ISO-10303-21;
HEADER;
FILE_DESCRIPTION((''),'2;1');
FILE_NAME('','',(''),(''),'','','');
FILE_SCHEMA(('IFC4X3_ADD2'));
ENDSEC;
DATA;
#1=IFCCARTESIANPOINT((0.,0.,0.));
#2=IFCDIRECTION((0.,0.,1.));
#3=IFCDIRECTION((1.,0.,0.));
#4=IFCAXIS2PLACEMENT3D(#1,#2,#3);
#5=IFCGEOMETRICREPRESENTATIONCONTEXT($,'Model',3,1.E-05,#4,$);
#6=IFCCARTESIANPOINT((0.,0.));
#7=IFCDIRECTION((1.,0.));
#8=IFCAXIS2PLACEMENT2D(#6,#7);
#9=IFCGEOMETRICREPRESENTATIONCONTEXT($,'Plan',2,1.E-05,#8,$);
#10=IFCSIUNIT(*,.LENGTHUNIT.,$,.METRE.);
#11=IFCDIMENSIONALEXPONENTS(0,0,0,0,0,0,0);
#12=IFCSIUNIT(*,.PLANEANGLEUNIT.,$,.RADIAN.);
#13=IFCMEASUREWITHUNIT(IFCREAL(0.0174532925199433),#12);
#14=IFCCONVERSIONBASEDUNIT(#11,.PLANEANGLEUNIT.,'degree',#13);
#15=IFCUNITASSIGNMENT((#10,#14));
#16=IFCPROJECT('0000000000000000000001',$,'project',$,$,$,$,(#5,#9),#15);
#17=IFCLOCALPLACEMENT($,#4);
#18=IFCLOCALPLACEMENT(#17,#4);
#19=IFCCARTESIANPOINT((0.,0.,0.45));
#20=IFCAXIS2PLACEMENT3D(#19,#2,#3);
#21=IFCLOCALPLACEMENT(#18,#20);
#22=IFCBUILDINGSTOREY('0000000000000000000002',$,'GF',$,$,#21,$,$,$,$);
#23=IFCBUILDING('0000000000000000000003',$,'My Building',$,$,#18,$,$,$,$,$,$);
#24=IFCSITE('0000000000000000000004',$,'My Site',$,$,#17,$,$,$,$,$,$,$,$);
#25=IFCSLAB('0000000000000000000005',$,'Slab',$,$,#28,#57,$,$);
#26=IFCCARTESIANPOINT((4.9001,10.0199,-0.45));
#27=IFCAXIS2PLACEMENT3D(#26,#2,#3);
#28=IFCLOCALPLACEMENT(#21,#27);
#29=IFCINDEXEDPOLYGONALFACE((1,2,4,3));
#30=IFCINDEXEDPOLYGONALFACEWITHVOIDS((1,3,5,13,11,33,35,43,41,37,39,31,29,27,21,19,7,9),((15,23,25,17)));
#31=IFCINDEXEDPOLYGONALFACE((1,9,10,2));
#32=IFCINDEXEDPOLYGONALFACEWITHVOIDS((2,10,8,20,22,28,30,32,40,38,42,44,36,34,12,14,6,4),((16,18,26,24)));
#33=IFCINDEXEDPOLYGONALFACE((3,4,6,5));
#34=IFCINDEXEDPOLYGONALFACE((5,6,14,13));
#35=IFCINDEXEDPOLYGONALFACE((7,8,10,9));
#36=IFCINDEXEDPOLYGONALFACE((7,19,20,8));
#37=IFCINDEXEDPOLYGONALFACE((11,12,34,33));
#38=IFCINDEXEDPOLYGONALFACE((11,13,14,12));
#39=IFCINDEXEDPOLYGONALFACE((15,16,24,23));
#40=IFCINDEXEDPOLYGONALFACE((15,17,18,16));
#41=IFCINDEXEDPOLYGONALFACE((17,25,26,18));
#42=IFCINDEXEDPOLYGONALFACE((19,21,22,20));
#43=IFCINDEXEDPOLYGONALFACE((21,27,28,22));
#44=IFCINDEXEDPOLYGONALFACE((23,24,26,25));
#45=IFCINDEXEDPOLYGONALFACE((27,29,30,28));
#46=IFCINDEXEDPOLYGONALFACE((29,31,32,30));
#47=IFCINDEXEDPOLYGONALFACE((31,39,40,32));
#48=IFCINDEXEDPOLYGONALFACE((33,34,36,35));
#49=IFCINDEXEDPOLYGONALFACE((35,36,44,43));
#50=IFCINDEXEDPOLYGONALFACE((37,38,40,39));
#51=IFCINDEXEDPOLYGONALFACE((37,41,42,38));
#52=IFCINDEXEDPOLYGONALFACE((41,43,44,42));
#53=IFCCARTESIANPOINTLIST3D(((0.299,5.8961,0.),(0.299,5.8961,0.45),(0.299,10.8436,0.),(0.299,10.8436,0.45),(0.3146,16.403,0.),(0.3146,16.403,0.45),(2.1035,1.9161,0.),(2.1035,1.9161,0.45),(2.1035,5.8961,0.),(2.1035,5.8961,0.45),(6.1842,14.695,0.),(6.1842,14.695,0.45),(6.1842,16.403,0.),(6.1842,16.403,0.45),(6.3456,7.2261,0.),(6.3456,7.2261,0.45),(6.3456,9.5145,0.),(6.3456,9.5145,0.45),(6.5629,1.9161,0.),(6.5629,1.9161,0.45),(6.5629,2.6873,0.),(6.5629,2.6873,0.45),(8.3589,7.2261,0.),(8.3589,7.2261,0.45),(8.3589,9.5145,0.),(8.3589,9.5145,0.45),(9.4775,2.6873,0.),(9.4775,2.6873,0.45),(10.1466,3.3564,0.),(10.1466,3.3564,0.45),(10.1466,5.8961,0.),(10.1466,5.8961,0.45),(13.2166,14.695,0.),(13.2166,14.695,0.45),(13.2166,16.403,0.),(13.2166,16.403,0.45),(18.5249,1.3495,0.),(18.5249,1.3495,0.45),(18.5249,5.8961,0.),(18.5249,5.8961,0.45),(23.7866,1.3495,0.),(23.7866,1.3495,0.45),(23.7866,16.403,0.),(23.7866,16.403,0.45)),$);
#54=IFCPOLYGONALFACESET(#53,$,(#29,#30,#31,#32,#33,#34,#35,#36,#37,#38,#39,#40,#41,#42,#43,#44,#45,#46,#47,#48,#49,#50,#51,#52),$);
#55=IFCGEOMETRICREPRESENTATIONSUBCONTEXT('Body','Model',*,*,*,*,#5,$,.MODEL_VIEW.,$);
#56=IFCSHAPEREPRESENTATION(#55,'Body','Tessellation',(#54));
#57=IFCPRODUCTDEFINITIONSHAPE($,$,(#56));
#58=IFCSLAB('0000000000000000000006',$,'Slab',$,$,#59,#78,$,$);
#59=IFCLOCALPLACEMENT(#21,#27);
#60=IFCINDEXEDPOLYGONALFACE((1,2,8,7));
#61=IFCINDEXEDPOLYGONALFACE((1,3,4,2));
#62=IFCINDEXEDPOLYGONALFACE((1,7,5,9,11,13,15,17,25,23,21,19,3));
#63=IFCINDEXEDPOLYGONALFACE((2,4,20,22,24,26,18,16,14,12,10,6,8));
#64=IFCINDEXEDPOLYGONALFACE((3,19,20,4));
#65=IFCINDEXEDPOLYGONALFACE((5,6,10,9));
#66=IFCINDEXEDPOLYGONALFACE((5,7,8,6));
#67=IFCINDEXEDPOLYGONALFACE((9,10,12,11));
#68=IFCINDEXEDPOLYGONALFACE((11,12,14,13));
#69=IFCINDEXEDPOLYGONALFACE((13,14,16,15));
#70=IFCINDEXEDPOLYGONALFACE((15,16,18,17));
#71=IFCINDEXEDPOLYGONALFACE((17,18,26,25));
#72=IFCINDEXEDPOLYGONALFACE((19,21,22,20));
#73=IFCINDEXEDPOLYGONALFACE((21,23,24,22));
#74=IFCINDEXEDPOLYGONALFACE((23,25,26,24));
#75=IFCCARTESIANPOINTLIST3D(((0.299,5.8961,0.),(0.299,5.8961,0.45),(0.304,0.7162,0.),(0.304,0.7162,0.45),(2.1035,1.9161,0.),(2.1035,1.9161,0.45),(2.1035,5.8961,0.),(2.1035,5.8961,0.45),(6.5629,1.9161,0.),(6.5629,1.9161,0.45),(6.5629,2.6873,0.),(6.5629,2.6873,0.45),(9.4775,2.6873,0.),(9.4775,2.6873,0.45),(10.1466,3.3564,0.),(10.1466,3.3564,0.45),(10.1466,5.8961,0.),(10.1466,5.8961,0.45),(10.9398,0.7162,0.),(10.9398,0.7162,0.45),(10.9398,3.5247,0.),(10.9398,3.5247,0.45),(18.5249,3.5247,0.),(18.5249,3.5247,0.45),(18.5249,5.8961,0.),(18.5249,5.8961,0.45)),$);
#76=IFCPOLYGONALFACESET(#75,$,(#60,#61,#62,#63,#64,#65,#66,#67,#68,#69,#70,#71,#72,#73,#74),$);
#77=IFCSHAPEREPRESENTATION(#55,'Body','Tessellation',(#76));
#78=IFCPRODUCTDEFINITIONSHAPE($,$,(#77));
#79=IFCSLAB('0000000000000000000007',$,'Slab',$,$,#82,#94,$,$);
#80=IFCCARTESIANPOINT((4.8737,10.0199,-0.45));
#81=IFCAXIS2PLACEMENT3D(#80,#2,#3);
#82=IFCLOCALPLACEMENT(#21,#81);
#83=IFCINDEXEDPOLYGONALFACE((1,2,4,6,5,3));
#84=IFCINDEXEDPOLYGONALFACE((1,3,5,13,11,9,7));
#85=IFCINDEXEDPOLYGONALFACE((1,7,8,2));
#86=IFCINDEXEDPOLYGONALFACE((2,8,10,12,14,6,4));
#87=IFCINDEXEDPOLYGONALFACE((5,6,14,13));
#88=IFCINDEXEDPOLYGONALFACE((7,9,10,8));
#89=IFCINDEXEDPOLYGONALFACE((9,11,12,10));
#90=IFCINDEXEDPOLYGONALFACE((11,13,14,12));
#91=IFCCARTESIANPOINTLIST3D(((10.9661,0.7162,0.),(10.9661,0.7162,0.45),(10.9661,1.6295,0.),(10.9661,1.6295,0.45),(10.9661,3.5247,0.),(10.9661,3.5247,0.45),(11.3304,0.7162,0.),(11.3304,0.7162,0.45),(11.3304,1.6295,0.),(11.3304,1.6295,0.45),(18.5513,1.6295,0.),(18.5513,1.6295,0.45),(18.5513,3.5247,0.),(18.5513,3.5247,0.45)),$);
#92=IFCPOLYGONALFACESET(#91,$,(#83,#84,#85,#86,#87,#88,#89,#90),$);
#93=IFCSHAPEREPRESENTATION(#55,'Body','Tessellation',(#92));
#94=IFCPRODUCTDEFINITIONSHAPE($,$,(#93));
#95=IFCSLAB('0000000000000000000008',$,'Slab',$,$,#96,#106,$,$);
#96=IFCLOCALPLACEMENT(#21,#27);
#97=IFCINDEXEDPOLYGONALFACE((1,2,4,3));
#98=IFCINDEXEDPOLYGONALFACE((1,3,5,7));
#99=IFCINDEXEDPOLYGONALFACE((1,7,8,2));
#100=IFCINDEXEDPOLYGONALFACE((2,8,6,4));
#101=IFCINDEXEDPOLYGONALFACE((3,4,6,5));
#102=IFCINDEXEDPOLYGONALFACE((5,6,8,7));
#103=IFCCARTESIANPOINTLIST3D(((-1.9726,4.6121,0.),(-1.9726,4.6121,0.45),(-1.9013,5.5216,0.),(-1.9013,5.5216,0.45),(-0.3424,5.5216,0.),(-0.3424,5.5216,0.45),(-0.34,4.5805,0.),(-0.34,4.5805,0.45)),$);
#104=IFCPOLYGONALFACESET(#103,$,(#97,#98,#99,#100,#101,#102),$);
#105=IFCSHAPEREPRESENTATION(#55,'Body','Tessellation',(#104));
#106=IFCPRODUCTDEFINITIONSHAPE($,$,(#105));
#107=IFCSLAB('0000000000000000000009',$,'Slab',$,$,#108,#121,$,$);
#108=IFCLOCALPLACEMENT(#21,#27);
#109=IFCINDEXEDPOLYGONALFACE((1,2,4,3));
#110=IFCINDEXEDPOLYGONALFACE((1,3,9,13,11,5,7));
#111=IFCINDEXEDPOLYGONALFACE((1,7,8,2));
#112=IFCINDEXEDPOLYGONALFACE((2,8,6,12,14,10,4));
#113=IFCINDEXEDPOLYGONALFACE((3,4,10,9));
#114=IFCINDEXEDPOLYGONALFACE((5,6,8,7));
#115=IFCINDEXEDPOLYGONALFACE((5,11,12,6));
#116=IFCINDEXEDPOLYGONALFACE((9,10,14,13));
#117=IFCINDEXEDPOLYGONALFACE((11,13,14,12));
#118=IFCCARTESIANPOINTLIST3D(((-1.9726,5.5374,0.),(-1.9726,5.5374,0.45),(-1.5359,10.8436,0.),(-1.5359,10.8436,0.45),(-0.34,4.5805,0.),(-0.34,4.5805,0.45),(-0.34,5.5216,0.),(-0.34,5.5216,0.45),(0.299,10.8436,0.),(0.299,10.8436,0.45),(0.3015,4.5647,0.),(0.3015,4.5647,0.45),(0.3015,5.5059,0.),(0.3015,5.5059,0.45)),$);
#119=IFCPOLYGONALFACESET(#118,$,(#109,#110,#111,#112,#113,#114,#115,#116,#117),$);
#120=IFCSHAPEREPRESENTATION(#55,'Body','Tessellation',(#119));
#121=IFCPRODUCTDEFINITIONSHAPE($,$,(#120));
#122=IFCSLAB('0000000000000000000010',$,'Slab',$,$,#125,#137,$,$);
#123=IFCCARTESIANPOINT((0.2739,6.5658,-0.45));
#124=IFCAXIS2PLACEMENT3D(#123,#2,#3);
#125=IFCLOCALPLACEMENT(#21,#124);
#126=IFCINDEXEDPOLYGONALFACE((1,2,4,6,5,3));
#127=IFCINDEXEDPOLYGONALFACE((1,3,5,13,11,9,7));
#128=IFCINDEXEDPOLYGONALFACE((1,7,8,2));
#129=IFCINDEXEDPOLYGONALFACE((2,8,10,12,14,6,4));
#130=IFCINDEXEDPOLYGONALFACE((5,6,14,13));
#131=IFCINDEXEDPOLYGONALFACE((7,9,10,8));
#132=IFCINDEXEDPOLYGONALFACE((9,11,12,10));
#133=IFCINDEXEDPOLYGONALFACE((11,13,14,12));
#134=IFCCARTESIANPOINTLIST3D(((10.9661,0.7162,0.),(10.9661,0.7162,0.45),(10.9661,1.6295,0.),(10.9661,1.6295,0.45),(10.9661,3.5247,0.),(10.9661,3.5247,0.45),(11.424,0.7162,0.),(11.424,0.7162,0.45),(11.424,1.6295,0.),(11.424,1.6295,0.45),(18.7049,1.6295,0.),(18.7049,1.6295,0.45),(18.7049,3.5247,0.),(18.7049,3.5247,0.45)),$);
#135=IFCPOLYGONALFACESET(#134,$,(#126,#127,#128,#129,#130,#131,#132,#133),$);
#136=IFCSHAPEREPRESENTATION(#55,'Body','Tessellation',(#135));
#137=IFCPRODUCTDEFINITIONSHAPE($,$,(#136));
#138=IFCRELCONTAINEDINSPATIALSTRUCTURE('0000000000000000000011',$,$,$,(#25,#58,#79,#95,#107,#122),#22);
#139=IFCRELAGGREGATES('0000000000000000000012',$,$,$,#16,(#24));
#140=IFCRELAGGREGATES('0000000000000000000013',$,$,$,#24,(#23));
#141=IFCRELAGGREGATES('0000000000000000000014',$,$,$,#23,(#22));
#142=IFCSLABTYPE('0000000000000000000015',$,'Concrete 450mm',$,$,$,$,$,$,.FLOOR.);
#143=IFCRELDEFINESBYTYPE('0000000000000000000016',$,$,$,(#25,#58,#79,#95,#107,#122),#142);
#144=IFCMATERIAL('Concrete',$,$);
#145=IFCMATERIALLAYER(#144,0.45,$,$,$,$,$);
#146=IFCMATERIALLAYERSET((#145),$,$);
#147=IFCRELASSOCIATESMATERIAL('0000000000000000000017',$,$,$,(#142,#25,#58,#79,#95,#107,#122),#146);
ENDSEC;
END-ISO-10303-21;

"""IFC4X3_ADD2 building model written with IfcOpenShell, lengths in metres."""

from ifc_helpers import new_model, entity, si_unit, converted_unit, frame, origin_with_axes, origin_2d_with_axis, place, context, subcontext, project, spatial, line, indexed_curve, outline, extrude, material, layer, layer_set, layer_usage, type_object, element, save


model = new_model("IFC4X3_ADD2")

# Units and contexts
model_context = context("Model", 3, precision=1e-05, world=origin_with_axes())
plan_context = context("Plan", 2, precision=1e-05, world=origin_2d_with_axis())
body_context_1 = subcontext(model_context, "Body", "Model", "MODEL_VIEW")
ifc_project = project(units=[si_unit("LENGTHUNIT", "METRE"), converted_unit("PLANEANGLEUNIT", "degree", entity("IfcReal", 0.0174532925199433), si_unit("PLANEANGLEUNIT", "RADIAN"), dimensions=[0, 0, 0, 0, 0, 0, 0])], contexts=[model_context, plan_context])

# Site, building, storey
site_placement = place(None, origin_with_axes())
site = spatial("IfcSite", under=ifc_project, at=site_placement, Name="My Site")
building_placement = place(site_placement, origin_with_axes())
building = spatial("IfcBuilding", under=site, at=building_placement, Name="My Building")
storey_placement = place(building_placement, frame((0.0, 0.0, 0.45), z_axis=(0.0, 0.0, 1.0), x_axis=(1.0, 0.0, 0.0)))
storey = spatial("IfcBuildingStorey", under=building, at=storey_placement, Name="GF")

# Slabs
ifc_material_1 = material(Name="Concrete")
ifc_layer_1 = layer(ifc_material_1, 0.45)
ifc_layer_set_1 = layer_set([ifc_layer_1])
ifc_layer_usage_1 = layer_usage(ifc_layer_set_1, "AXIS3", "POSITIVE", 0.0)
slab_type = type_object("IfcSlabType", Name="Concrete 450mm", PredefinedType="FLOOR", material=ifc_layer_set_1)
slab_1_placement = place(storey_placement, frame((4.9001, 10.0199, -0.45), z_axis=(0.0, 0.0, 1.0), x_axis=(1.0, 0.0, 0.0)))
element("IfcSlab", 1, at=slab_1_placement, inside=storey, type_object=slab_type, material=ifc_layer_usage_1, Name="Slab", context=body_context_1, shape_type="SolidModel", body=[
    extrude(outline(indexed_curve([(6.5629, 1.9161), (6.5629, 2.6873), (9.4775, 2.6873), (10.1466, 3.3564), (10.1466, 5.8961), (18.5249, 5.8961), (18.5249, 1.3495), (23.7866, 1.3495), (23.7866, 16.403), (13.2166, 16.403), (13.2166, 14.695), (6.1842, 14.695), (6.1842, 16.403), (0.3146, 16.403), (0.299, 10.8436), (0.299, 5.8961), (2.1035, 5.8961), (2.1035, 1.9161), (6.5629, 1.9161)]), holes=[indexed_curve([(6.3456, 9.5145), (8.3589, 9.5145), (8.3589, 7.2261), (6.3456, 7.2261), (6.3456, 9.5145)])]), None, (0.0, 0.0, 1.0), 0.45),
])
ifc_layer_usage_2 = layer_usage(ifc_layer_set_1, "AXIS3", "POSITIVE", 0.0)
slab_2_placement = place(storey_placement, frame((4.9001, 10.0199, -0.45), z_axis=(0.0, 0.0, 1.0), x_axis=(1.0, 0.0, 0.0)))
element("IfcSlab", 2, at=slab_2_placement, inside=storey, type_object=slab_type, material=ifc_layer_usage_2, Name="Slab", context=body_context_1, shape_type="SweptSolid", body=[
    extrude(outline(indexed_curve([(18.5249, 5.8961), (10.1466, 5.8961), (10.1466, 3.3564), (9.4775, 2.6873), (6.5629, 2.6873), (6.5629, 1.9161), (2.1035, 1.9161), (2.1035, 5.8961), (0.299, 5.8961), (0.304, 0.7162), (10.9398, 0.7162), (10.9398, 3.5247), (18.5249, 3.5247)], segments=[line(10, 9), line(9, 8), line(8, 7), line(7, 6), line(6, 5), line(5, 4), line(4, 3), line(3, 2), line(2, 1), line(1, 13), line(13, 12), line(12, 11), line(11, 10)], self_intersect=False)), None, (0.0, 0.0, 1.0), 0.45),
])
ifc_layer_usage_3 = layer_usage(ifc_layer_set_1, "AXIS3", "POSITIVE", 0.0)
slab_3_placement = place(storey_placement, frame((4.8737, 10.0199, -0.45), z_axis=(0.0, 0.0, 1.0), x_axis=(1.0, 0.0, 0.0)))
element("IfcSlab", 3, at=slab_3_placement, inside=storey, type_object=slab_type, material=ifc_layer_usage_3, Name="Slab", context=body_context_1, shape_type="SolidModel", body=[
    extrude(outline(indexed_curve([(10.9661, 1.6295), (10.9661, 3.5247), (18.5513, 3.5247), (18.5513, 1.6295), (11.3304, 1.6295), (11.3304, 0.7162), (10.9661, 0.7162), (10.9661, 1.6295)])), None, (0.0, 0.0, 1.0), 0.45),
])
ifc_layer_usage_4 = layer_usage(ifc_layer_set_1, "AXIS3", "POSITIVE", 0.0)
slab_4_placement = place(storey_placement, frame((4.9001, 10.0199, -0.45), z_axis=(0.0, 0.0, 1.0), x_axis=(1.0, 0.0, 0.0)))
element("IfcSlab", 4, at=slab_4_placement, inside=storey, type_object=slab_type, material=ifc_layer_usage_4, Name="Slab", context=body_context_1, shape_type="SweptSolid", body=[
    extrude(outline(indexed_curve([(-1.9726, 4.6121), (-1.9013, 5.5216), (-0.3424, 5.5216), (-0.34, 4.5805)], segments=[line(4, 1), line(1, 2), line(2, 3), line(3, 4)], self_intersect=False)), None, (0.0, 0.0, 1.0), 0.45),
])
ifc_layer_usage_5 = layer_usage(ifc_layer_set_1, "AXIS3", "POSITIVE", 0.0)
slab_5_placement = place(storey_placement, frame((4.9001, 10.0199, -0.45), z_axis=(0.0, 0.0, 1.0), x_axis=(1.0, 0.0, 0.0)))
element("IfcSlab", 5, at=slab_5_placement, inside=storey, type_object=slab_type, material=ifc_layer_usage_5, Name="Slab", context=body_context_1, shape_type="SweptSolid", body=[
    extrude(outline(indexed_curve([(0.3015, 5.5059), (0.299, 10.8436), (-1.5359, 10.8436), (-1.9726, 5.5374), (-0.34, 5.5216), (0.3015, 4.5647), (-0.34, 4.5805)], segments=[line(7, 5), line(5, 4), line(4, 3), line(3, 2), line(2, 1), line(1, 6), line(6, 7)], self_intersect=False)), None, (0.0, 0.0, 1.0), 0.45),
])
ifc_layer_usage_6 = layer_usage(ifc_layer_set_1, "AXIS3", "POSITIVE", 0.0)
slab_6_placement = place(storey_placement, frame((0.2739, 6.5658, -0.45), z_axis=(0.0, 0.0, 1.0), x_axis=(1.0, 0.0, 0.0)))
element("IfcSlab", 6, at=slab_6_placement, inside=storey, type_object=slab_type, material=ifc_layer_usage_6, Name="Slab", context=body_context_1, shape_type="SweptSolid", body=[
    extrude(outline(indexed_curve([(11.424, 0.7162), (11.424, 1.6295), (18.7049, 1.6295), (18.7049, 3.5247), (10.9661, 3.5247), (10.9661, 1.6295), (10.9661, 0.7162)], segments=[line(6, 5), line(5, 4), line(4, 3), line(3, 2), line(2, 1), line(1, 7), line(7, 6)], self_intersect=False)), None, (0.0, 0.0, 1.0), 0.45),
])

save(model, "model.ifc")
